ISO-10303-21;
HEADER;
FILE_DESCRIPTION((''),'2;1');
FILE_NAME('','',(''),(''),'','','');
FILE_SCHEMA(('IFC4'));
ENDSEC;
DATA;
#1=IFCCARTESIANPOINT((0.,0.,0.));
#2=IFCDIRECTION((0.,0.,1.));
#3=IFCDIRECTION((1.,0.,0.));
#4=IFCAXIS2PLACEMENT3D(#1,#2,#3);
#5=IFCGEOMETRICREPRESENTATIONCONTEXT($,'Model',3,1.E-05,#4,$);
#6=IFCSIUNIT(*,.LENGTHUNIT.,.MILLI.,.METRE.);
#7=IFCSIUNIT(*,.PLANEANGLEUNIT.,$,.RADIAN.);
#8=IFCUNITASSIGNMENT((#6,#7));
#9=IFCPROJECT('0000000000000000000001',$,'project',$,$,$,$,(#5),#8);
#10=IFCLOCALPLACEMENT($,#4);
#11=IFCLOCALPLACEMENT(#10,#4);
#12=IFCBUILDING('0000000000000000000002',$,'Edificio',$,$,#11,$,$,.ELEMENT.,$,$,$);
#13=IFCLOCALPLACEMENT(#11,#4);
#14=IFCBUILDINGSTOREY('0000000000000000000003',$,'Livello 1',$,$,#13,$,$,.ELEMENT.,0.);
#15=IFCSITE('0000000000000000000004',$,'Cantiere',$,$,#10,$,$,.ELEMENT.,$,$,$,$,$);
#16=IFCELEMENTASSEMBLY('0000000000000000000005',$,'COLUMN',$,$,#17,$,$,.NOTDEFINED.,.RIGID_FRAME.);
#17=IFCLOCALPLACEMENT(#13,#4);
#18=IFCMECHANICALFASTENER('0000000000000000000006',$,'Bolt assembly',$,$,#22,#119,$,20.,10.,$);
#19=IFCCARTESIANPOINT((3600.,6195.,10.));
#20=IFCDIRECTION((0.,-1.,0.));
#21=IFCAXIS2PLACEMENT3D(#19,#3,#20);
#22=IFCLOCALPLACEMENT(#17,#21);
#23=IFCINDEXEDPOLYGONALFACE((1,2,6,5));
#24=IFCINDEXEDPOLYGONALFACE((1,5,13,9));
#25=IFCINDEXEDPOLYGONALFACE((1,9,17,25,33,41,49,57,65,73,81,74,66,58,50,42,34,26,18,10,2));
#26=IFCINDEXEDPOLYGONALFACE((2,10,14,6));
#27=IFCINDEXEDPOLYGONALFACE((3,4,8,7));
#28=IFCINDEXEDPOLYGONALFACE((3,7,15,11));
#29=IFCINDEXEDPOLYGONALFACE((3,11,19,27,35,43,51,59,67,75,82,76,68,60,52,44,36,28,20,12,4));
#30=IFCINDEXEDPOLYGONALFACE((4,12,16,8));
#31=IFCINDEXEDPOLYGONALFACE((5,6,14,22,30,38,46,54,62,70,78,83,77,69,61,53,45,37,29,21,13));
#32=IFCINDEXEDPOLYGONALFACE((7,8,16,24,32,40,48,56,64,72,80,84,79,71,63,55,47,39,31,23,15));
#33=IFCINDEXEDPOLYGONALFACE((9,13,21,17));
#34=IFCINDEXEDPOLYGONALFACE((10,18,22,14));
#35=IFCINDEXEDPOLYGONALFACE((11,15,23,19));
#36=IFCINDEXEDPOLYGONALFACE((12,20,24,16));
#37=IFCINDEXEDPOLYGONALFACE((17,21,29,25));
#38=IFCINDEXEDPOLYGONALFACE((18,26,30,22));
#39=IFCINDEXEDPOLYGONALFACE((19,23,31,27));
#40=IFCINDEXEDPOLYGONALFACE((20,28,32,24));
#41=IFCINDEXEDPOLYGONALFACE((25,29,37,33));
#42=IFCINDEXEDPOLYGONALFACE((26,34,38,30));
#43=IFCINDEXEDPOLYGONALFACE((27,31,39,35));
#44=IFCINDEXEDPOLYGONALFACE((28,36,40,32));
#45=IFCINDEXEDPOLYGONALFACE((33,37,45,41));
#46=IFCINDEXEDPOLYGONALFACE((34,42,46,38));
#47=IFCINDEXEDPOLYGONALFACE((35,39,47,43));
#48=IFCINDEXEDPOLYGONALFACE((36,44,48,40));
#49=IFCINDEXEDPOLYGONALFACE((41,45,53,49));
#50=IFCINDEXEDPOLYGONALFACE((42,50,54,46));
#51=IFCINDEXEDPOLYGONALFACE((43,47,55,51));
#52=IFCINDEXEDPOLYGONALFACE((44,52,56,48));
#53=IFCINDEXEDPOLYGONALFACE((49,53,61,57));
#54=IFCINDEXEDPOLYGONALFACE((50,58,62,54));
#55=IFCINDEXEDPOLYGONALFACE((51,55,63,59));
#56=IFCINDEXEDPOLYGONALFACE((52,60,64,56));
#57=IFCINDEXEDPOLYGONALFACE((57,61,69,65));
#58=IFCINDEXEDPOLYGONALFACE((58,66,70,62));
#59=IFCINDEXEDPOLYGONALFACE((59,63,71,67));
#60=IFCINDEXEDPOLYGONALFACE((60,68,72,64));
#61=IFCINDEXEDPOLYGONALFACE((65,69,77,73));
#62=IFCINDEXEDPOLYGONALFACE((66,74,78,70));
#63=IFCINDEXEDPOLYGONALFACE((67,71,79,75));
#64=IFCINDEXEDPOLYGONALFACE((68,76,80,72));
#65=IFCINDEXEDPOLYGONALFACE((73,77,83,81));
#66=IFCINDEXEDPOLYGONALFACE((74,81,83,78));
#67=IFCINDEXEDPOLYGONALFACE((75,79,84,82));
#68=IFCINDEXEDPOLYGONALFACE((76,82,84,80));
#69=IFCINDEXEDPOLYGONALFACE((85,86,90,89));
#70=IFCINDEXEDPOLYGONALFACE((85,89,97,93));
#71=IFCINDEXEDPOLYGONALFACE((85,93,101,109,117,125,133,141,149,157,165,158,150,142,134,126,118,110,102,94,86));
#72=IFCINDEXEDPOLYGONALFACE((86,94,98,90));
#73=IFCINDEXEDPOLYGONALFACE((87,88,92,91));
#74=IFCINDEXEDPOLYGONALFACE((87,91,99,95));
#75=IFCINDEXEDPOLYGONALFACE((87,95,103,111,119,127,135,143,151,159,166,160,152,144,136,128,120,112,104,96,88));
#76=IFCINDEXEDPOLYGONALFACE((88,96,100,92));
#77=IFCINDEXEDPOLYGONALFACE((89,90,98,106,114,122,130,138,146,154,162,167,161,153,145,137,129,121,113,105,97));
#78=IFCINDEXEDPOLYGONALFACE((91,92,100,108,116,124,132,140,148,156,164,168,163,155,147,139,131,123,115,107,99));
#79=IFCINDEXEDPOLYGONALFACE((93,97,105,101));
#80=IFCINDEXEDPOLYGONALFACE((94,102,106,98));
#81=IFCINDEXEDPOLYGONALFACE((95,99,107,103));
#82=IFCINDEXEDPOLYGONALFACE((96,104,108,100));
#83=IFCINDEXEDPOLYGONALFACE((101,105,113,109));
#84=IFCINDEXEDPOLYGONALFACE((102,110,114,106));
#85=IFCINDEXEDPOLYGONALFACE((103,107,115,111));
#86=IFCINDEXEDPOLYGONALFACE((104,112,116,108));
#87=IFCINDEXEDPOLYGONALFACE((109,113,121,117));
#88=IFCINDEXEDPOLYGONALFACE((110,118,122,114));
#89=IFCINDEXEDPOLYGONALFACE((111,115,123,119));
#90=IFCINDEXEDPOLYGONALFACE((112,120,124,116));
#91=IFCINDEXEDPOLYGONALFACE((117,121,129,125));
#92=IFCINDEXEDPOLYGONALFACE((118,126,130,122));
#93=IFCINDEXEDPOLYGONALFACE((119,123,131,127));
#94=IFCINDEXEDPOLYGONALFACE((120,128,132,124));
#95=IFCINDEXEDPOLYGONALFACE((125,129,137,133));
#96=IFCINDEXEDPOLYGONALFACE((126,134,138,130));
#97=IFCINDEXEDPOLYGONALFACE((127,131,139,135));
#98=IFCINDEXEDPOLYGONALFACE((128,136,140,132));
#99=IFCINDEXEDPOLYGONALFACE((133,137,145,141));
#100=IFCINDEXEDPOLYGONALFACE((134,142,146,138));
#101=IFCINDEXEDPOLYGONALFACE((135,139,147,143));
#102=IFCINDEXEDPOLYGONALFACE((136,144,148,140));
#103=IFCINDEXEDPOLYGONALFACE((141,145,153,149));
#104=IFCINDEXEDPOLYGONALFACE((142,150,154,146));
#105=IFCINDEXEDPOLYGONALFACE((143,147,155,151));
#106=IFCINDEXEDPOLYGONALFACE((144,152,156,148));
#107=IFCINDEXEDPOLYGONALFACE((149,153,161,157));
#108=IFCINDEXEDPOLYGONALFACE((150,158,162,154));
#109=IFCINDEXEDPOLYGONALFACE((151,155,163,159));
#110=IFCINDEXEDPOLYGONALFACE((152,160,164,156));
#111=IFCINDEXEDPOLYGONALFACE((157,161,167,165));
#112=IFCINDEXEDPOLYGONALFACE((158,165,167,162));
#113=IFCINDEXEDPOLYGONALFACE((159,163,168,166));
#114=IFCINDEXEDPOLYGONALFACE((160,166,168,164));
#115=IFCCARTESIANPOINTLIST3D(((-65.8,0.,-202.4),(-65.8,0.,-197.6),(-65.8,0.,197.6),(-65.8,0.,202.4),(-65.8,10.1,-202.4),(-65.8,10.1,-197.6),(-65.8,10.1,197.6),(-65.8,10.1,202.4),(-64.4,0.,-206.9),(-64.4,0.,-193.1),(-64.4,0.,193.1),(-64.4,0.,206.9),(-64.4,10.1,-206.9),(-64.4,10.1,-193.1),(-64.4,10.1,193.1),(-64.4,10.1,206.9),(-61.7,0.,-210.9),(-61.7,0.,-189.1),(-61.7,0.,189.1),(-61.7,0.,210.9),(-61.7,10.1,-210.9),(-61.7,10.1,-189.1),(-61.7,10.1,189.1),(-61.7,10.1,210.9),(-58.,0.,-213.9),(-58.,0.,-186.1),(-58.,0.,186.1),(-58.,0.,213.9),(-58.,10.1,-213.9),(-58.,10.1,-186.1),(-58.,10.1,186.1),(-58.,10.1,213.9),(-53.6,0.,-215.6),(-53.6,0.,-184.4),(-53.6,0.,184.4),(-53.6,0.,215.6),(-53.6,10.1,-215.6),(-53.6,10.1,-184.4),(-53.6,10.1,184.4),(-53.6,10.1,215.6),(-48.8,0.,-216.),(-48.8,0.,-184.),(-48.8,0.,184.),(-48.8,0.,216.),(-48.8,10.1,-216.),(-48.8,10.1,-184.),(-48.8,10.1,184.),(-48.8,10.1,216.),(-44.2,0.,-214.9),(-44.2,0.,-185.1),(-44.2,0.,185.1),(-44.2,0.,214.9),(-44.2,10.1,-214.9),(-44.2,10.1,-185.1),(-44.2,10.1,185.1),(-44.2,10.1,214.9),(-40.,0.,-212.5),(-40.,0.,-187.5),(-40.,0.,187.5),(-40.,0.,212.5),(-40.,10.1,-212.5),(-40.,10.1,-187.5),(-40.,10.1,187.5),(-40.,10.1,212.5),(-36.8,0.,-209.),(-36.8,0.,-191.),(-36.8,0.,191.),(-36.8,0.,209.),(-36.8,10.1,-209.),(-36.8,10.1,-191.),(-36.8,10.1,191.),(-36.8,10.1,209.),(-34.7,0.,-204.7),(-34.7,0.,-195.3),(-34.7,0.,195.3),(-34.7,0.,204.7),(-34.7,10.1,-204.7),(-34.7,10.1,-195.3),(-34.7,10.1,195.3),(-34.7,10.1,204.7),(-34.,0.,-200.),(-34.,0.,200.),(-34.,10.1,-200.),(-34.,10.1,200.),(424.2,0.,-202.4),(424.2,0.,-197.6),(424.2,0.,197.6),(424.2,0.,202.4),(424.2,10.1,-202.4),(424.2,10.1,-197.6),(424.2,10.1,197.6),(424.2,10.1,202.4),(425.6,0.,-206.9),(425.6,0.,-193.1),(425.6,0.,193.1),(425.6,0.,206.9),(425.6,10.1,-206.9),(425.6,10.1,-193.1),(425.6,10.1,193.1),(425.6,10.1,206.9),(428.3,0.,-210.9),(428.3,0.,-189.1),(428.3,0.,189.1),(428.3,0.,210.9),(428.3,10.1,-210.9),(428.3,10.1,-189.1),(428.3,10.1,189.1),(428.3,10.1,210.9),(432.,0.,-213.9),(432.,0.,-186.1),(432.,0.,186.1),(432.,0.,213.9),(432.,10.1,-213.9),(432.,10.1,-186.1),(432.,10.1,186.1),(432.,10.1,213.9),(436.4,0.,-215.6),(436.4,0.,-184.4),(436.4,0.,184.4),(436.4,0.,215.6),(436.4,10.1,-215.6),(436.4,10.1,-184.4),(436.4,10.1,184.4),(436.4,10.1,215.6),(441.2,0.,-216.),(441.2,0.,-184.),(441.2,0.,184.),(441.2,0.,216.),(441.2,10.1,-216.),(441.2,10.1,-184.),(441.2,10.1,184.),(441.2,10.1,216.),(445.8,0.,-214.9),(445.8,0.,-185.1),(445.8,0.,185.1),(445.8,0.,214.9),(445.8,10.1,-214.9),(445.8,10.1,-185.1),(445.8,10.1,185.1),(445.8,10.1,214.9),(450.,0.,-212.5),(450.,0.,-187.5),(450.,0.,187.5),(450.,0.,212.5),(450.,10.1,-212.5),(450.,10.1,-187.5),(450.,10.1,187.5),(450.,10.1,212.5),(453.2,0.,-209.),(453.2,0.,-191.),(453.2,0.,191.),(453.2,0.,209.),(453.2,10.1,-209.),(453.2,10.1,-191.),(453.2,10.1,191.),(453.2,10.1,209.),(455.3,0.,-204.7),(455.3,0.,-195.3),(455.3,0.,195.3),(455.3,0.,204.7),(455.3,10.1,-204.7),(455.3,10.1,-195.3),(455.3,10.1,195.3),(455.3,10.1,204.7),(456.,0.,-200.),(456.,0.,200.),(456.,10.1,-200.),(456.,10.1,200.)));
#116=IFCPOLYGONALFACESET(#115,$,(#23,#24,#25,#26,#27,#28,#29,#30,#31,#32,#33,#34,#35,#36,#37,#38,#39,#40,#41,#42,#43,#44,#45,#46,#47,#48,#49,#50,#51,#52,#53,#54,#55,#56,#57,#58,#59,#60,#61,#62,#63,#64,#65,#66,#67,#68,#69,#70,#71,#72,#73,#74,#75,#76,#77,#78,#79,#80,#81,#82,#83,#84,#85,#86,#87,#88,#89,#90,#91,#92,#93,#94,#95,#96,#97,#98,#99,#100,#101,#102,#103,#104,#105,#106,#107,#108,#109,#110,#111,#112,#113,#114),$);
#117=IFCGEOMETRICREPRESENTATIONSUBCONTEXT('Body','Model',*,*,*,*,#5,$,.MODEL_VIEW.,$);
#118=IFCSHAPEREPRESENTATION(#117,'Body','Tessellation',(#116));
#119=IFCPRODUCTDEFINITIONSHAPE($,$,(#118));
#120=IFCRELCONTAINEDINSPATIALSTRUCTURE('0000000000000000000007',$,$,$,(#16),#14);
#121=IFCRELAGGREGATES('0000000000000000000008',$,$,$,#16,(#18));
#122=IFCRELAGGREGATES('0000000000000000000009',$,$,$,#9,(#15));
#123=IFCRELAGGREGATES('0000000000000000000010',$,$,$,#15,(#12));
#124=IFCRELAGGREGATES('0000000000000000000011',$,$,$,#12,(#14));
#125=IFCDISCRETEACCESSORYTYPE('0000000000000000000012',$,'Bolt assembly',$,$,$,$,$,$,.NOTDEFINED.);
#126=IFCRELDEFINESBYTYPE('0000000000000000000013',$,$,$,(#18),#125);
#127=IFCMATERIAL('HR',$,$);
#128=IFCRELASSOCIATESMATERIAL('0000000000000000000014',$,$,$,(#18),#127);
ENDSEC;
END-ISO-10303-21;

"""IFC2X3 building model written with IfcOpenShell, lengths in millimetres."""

from ifc_helpers import new_model, si_unit, frame, origin_with_axes, origin_2d_with_axis, place, context, subcontext, project, spatial, circle, extrude, source, transform, mapped, material, type_object, element, aggregate, save


model = new_model("IFC2X3")

# Units and contexts
model_context = context("Model", 3, precision=1e-05, world=origin_with_axes())
body_context = subcontext(model_context, "Body", "Model", "MODEL_VIEW")
ifc_project = project(units=[si_unit("LENGTHUNIT", "METRE", prefix="MILLI"), si_unit("PLANEANGLEUNIT", "RADIAN")], contexts=[model_context])

# Site, building, storey
site_placement = place(None, origin_with_axes())
site = spatial("IfcSite", under=ifc_project, at=site_placement, Name="Cantiere", CompositionType="ELEMENT")
building_placement = place(site_placement, origin_with_axes())
building = spatial("IfcBuilding", under=site, at=building_placement, Name="Edificio", CompositionType="ELEMENT")
storey_placement = place(building_placement, origin_with_axes())
storey = spatial("IfcBuildingStorey", under=building, at=storey_placement, Name="Livello 1", CompositionType="ELEMENT", Elevation=0.0)

# Element assembly
assembly_1_placement = place(storey_placement, origin_with_axes())
assembly_1 = element("IfcElementAssembly", 1, at=assembly_1_placement, inside=storey, Name="COLUMN", AssemblyPlace="NOTDEFINED", PredefinedType="RIGID_FRAME")

# Mechanical fastener
ifc_material_1 = material(Name="HR")
discrete_accessory_type_1 = type_object("IfcDiscreteAccessoryType", Name="Bolt assembly")
shared_shape_1 = source(origin_with_axes(), body_context, "Body", "SweptSolid", [
    extrude(circle(Radius=16.0, at=origin_2d_with_axis()), frame((0.0, 0.0, 0.0), z_axis=(0.0, 1.0, 0.0), x_axis=(1.0, 0.0, 0.0)), (0.0, 0.0, 1.0), 10.1),
])
mechanical_fastener_1_placement = place(assembly_1_placement, frame((3600.0, 6195.0, 10.0), z_axis=(1.0, 0.0, 0.0), x_axis=(0.0, -1.0, 0.0)))
mechanical_fastener_1 = element("IfcMechanicalFastener", 2, at=mechanical_fastener_1_placement, type_object=discrete_accessory_type_1, material=ifc_material_1, Name="Bolt assembly", NominalDiameter=20.0, NominalLength=10.0, context=body_context, shape_type="MappedRepresentation", body=[
    mapped(shared_shape_1, transform((-50.0, 0.0, -200.0))),
    mapped(shared_shape_1, transform((-50.0, 0.0, 200.0))),
    mapped(shared_shape_1, transform((440.0, 0.0, -200.0))),
    mapped(shared_shape_1, transform((440.0, 0.0, 200.0))),
])

aggregate(assembly_1, [mechanical_fastener_1])

save(model, "model.ifc")
